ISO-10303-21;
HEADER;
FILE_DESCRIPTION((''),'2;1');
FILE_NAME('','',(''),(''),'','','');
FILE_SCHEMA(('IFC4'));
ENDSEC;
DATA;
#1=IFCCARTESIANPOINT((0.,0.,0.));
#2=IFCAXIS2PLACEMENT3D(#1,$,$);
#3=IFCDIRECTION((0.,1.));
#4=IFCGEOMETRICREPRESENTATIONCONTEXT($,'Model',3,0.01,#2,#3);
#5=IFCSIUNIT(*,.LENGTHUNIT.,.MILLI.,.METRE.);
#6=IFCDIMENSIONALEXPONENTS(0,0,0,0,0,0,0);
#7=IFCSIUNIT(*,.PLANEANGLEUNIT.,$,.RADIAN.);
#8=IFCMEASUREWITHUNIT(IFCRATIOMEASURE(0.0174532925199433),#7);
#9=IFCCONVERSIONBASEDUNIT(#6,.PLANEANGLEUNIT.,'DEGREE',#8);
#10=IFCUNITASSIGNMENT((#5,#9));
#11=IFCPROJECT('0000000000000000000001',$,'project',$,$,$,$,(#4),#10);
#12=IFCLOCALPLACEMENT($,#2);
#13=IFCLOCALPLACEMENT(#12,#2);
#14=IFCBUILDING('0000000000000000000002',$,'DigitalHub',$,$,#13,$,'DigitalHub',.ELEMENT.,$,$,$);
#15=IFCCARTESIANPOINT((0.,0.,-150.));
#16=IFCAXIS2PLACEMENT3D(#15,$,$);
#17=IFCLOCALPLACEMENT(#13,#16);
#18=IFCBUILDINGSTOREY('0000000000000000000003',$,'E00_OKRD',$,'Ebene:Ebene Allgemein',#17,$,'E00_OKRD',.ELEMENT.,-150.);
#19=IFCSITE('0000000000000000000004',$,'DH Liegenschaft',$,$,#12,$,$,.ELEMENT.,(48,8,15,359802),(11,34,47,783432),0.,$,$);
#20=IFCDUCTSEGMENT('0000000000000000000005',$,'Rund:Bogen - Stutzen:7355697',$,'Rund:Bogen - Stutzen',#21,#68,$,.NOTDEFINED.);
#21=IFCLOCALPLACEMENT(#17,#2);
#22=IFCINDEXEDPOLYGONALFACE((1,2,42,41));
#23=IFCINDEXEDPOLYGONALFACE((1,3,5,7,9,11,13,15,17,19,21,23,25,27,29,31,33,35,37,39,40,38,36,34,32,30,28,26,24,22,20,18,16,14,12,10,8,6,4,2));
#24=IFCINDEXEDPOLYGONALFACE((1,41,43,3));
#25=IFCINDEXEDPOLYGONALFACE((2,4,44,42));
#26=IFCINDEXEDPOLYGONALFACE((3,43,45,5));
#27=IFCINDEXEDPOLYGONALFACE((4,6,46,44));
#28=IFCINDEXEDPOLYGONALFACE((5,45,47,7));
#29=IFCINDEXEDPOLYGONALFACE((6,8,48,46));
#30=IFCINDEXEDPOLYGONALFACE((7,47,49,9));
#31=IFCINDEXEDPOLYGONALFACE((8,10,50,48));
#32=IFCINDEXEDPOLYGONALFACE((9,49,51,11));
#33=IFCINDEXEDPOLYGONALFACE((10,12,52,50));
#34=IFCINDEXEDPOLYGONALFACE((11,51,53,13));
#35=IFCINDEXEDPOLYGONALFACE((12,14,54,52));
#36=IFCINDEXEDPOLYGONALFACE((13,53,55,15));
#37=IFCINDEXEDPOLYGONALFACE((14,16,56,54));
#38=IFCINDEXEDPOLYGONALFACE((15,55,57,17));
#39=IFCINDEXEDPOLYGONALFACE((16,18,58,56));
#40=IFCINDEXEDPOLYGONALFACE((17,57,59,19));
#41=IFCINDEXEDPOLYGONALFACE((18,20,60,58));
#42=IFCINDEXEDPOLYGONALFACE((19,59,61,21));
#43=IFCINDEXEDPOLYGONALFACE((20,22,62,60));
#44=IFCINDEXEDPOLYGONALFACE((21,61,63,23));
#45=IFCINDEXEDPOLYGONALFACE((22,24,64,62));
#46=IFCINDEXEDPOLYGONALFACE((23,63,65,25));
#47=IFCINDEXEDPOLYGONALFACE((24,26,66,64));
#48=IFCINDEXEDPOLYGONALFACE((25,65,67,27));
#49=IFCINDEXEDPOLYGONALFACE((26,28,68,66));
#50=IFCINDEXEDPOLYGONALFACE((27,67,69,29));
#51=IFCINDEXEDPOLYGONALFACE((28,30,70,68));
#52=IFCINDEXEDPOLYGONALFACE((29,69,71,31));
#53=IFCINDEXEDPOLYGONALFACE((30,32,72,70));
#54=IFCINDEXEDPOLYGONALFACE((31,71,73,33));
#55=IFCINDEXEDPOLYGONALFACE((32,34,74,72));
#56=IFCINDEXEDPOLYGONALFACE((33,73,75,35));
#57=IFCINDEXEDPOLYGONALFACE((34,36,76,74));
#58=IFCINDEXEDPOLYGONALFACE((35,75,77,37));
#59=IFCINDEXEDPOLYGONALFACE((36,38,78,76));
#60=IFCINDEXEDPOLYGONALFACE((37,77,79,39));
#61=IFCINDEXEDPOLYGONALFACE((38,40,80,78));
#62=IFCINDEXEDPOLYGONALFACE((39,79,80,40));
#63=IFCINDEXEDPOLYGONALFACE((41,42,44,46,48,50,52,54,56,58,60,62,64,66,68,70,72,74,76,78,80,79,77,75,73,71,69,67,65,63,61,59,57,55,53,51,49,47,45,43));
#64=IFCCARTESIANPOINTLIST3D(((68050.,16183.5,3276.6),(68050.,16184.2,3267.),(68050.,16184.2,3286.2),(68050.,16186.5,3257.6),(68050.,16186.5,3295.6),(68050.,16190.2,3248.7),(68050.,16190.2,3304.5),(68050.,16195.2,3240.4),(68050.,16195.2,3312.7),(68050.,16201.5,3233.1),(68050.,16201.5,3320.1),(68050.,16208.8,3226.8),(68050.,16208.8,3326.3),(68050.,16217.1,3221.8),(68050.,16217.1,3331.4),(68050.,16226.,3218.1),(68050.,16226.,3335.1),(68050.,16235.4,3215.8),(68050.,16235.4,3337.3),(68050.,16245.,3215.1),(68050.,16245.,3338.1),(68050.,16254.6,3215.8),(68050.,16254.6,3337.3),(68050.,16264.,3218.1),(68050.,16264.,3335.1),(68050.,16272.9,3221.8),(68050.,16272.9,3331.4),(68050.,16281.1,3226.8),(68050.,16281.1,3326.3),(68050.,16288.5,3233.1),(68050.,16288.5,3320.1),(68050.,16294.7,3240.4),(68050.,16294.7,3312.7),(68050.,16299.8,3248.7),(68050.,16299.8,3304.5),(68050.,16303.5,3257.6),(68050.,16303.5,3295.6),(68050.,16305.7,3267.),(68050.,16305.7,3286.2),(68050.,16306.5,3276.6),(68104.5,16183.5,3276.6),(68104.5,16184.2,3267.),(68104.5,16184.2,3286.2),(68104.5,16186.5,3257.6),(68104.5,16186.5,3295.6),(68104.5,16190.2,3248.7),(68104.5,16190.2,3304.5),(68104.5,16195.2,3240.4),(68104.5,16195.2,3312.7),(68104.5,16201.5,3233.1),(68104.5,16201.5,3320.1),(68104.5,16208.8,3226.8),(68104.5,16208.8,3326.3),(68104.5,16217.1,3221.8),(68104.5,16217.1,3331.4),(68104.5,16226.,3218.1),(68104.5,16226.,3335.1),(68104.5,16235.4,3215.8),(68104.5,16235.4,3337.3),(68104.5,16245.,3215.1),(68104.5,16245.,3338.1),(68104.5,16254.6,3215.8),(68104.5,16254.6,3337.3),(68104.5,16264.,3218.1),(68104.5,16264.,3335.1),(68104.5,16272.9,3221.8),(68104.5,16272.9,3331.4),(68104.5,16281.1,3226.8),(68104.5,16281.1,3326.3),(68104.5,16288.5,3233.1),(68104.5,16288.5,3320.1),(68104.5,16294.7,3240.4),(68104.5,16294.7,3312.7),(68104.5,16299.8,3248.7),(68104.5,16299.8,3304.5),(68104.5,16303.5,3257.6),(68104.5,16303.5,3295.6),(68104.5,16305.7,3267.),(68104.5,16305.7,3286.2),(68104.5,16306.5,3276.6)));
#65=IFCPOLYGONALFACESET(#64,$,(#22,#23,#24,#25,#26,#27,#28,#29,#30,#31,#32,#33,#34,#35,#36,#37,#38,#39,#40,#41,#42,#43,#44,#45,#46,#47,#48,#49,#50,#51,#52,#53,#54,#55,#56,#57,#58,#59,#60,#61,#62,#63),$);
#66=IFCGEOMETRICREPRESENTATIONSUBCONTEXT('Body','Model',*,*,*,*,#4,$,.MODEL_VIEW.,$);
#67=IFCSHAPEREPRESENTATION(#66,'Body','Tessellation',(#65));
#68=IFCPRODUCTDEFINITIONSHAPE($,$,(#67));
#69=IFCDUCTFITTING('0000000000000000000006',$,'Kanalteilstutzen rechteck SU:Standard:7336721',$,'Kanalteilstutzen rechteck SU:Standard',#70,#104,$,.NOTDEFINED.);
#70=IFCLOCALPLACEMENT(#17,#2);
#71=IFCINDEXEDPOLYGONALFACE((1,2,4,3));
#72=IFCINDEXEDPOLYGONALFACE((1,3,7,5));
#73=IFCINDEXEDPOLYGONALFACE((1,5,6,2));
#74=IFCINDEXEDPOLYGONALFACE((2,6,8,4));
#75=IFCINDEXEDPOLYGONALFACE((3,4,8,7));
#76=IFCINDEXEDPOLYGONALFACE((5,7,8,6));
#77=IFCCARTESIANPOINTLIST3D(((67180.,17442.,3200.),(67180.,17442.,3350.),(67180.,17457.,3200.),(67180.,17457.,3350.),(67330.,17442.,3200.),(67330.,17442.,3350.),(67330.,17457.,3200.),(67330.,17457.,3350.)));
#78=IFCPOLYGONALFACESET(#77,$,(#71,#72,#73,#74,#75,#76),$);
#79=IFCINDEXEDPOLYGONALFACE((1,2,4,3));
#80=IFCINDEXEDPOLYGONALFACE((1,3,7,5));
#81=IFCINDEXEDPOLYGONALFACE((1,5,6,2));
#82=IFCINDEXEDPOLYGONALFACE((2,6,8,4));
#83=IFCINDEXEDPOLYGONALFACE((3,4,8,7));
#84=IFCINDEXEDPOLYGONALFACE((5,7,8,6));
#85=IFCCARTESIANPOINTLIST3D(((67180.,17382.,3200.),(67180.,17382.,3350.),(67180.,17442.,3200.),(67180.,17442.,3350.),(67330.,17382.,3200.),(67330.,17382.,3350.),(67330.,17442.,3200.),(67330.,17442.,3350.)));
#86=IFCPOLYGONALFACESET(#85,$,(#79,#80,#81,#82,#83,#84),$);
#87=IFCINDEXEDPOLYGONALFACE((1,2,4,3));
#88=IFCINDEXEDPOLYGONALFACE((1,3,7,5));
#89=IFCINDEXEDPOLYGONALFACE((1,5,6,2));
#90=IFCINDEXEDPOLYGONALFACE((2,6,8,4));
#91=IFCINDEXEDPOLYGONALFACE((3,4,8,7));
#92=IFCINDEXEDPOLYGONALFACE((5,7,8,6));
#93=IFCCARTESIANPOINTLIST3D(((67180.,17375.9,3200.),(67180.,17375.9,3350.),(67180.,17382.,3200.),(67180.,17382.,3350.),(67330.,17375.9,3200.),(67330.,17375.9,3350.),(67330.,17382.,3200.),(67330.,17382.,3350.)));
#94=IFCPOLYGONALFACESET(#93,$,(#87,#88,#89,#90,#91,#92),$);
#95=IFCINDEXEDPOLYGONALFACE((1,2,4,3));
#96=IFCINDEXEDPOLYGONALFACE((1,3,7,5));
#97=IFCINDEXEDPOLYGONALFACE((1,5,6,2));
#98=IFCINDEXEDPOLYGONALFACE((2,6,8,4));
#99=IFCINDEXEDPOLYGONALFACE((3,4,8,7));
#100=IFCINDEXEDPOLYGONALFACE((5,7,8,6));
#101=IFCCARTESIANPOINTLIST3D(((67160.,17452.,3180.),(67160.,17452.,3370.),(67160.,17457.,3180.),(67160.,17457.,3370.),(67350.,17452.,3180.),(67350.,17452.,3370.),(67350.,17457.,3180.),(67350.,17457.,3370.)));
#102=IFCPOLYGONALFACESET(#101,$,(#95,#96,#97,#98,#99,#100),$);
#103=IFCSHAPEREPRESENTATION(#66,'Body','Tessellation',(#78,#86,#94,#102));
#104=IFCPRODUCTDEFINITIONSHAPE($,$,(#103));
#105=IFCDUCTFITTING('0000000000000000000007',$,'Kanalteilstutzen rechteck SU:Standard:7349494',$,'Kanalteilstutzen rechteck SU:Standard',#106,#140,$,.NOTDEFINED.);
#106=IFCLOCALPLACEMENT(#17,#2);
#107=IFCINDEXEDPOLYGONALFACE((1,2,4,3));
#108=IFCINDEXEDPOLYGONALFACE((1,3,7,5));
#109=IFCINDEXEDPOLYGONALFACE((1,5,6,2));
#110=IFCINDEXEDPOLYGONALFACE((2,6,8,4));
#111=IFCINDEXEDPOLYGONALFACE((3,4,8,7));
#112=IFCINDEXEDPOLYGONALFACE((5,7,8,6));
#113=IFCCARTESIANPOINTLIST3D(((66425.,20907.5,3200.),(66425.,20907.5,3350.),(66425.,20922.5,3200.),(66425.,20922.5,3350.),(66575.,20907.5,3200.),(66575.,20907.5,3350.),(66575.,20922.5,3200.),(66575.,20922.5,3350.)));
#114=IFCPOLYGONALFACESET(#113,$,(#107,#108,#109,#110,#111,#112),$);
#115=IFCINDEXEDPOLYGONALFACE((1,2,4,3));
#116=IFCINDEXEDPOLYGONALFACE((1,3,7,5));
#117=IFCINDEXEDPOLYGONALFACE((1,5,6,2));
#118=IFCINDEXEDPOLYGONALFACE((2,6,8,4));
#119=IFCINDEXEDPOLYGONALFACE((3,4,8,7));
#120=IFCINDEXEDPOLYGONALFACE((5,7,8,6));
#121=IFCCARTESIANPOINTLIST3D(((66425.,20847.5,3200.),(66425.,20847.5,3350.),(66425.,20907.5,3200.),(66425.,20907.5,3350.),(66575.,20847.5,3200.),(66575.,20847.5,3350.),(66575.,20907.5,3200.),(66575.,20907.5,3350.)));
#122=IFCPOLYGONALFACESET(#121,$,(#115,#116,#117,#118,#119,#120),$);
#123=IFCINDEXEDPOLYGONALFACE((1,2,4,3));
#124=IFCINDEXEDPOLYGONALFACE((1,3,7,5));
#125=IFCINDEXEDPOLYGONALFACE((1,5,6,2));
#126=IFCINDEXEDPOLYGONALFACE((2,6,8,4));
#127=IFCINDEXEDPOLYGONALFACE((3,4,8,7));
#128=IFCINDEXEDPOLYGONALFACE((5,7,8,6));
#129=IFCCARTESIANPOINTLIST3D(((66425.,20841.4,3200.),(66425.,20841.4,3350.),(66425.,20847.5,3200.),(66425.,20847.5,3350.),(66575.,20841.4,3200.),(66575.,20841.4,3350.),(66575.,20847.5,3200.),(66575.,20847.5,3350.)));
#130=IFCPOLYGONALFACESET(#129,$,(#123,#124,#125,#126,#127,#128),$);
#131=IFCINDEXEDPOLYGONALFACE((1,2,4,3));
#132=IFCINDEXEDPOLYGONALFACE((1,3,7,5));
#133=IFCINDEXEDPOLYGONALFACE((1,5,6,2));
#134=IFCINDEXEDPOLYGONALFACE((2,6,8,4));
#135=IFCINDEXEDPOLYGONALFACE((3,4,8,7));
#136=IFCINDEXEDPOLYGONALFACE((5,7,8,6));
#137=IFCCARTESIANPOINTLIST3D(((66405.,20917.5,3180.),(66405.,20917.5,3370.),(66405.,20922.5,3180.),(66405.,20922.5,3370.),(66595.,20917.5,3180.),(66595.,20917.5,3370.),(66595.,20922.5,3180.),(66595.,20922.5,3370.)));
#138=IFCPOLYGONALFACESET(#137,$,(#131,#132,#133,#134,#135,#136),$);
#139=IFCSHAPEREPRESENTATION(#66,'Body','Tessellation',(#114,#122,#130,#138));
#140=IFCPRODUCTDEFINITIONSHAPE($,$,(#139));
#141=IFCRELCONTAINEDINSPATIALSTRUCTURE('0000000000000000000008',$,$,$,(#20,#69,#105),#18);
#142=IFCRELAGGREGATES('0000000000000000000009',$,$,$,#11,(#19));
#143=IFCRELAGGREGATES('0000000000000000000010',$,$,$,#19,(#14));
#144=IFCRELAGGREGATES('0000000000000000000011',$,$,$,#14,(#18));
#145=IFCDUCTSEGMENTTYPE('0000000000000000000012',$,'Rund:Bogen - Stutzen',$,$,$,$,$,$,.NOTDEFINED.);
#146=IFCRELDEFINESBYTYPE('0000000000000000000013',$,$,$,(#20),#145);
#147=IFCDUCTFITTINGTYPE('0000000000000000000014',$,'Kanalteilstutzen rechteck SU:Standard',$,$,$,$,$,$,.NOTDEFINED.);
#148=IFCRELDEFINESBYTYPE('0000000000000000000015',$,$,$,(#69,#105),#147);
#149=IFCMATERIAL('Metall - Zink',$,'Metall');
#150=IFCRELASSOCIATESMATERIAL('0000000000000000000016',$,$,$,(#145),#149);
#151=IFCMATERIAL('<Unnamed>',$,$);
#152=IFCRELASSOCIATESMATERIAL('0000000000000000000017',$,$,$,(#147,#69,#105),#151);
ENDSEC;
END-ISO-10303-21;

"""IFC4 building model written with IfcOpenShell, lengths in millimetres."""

from ifc_helpers import new_model, entity, si_unit, converted_unit, direction, frame, origin, place, context, subcontext, project, spatial, indexed_curve, outline, extrude, source, transform, mapped, material, type_object, type_shapes, element, save


model = new_model("IFC4")

# Units and contexts
model_context = context("Model", 3, precision=0.01, world=origin(), true_north=direction((0.0, 1.0)))
body_context = subcontext(model_context, "Body", "Model", "MODEL_VIEW")
ifc_project = project(units=[si_unit("LENGTHUNIT", "METRE", prefix="MILLI"), converted_unit("PLANEANGLEUNIT", "DEGREE", entity("IfcRatioMeasure", 0.0174532925199433), si_unit("PLANEANGLEUNIT", "RADIAN"), dimensions=[0, 0, 0, 0, 0, 0, 0])], contexts=[model_context])

# Site, building, storey
site_placement = place(None, origin())
site = spatial("IfcSite", under=ifc_project, at=site_placement, Name="DH Liegenschaft", CompositionType="ELEMENT", RefLatitude=(48, 8, 15, 359802), RefLongitude=(11, 34, 47, 783432), RefElevation=0.0)
building_placement = place(site_placement, origin())
building = spatial("IfcBuilding", under=site, at=building_placement, Name="DigitalHub", LongName="DigitalHub", CompositionType="ELEMENT")
storey_placement = place(building_placement, frame((0.0, 0.0, -150.0)))
storey = spatial("IfcBuildingStorey", under=building, at=storey_placement, Name="E00_OKRD", ObjectType="Ebene:Ebene Allgemein", LongName="E00_OKRD", CompositionType="ELEMENT", Elevation=-150.0)

# Shared definitions
ifc_material_1 = material(Name="Metall - Zink", Category="Metall")

# Shared definitions
ifc_material_2 = material(Name="<Unnamed>")

# Duct segment
duct_segment_type_1 = type_object("IfcDuctSegmentType", Name="Rund:Bogen - Stutzen", PredefinedType="NOTDEFINED", material=ifc_material_1)
duct_segment_1_placement = place(storey_placement, frame((68050.0, 16181.9, 3213.5)))
element("IfcDuctSegment", 1, at=duct_segment_1_placement, inside=storey, type_object=duct_segment_type_1, Name="Rund:Bogen - Stutzen:7355697", ObjectType="Rund:Bogen - Stutzen", PredefinedType="NOTDEFINED", context=body_context, shape_type="SweptSolid", body=[
    extrude(outline(indexed_curve([(61.5, 0.0), (60.7, 9.6), (58.5, 19.0), (54.8, 27.9), (49.8, 36.1), (43.5, 43.5), (36.1, 49.8), (27.9, 54.8), (19.0, 58.5), (9.6, 60.7), (0.0, 61.5), (-9.6, 60.7), (-19.0, 58.5), (-27.9, 54.8), (-36.1, 49.8), (-43.5, 43.5), (-49.8, 36.1), (-54.8, 27.9), (-58.5, 19.0), (-60.7, 9.6), (-61.5, 0.0), (-60.7, -9.6), (-58.5, -19.0), (-54.8, -27.9), (-49.8, -36.1), (-43.5, -43.5), (-36.1, -49.8), (-27.9, -54.8), (-19.0, -58.5), (-9.6, -60.7), (0.0, -61.5), (9.6, -60.7), (19.0, -58.5), (27.9, -54.8), (36.1, -49.8), (43.5, -43.5), (49.8, -36.1), (54.8, -27.9), (58.5, -19.0), (60.7, -9.6), (61.5, 0.0)], self_intersect=False)), frame((0.0, 63.1, 63.1), z_axis=(1.0, 0.0, 0.0), x_axis=(0.0, -1.0, 0.0)), (0.0, 0.0, 1.0), 54.5),
])

# Duct fittings
duct_fitting_type_1 = type_object("IfcDuctFittingType", Name="Kanalteilstutzen rechteck SU:Standard", PredefinedType="NOTDEFINED", material=ifc_material_2)
shared_shape_1 = source(origin(), body_context, "Body", "SweptSolid", [
    extrude(outline(indexed_curve([(-75.0, -7.5), (75.0, -7.5), (75.0, 7.5), (-75.0, 7.5), (-75.0, -7.5)], self_intersect=False)), frame((67.5, 0.0, -75.0), z_axis=(0.0, 0.0, 1.0), x_axis=(0.0, -1.0, 0.0)), (0.0, 0.0, 1.0), 150.0),
    extrude(outline(indexed_curve([(-75.0, -30.0), (75.0, -30.0), (75.0, 30.0), (-75.0, 30.0), (-75.0, -30.0)], self_intersect=False)), frame((30.0, 0.0, -75.0), z_axis=(0.0, 0.0, 1.0), x_axis=(0.0, -1.0, 0.0)), (0.0, 0.0, 1.0), 150.0),
    extrude(outline(indexed_curve([(-75.0, -3.0), (75.0, -3.0), (75.0, 3.0), (-75.0, 3.0), (-75.0, -3.0)], self_intersect=False)), frame((-3.0, 0.0, -75.0), z_axis=(0.0, 0.0, 1.0), x_axis=(0.0, -1.0, 0.0)), (0.0, 0.0, 1.0), 150.0),
    extrude(outline(indexed_curve([(-95.0, -2.5), (95.0, -2.5), (95.0, 2.5), (-95.0, 2.5), (-95.0, -2.5)], self_intersect=False)), frame((72.5, 0.0, -95.0), z_axis=(0.0, 0.0, 1.0), x_axis=(0.0, -1.0, 0.0)), (0.0, 0.0, 1.0), 190.0),
])
type_shapes(duct_fitting_type_1, [shared_shape_1])
for number, where, z_axis, x_axis, name in (
    (2, (67255.0, 17382.0, 3275.0), (0.0, 0.0, -1.0), (0.0, 1.0, 0.0), "Kanalteilstutzen rechteck SU:Standard:7336721"),
    (3, (66500.0, 20847.5, 3275.0), (0.0, 0.0, -1.0), (0.0, 1.0, 0.0), "Kanalteilstutzen rechteck SU:Standard:7349494"),
):
    element("IfcDuctFitting", number, at=place(storey_placement, frame(where, z_axis=z_axis, x_axis=x_axis)), inside=storey, type_object=duct_fitting_type_1, material=ifc_material_2, Name=name, ObjectType="Kanalteilstutzen rechteck SU:Standard", PredefinedType="NOTDEFINED", context=body_context, shape_type="MappedRepresentation", body=[
        mapped(shared_shape_1, transform((0.0, 0.0, 0.0), scale=1.0)),
    ])

save(model, "model.ifc")
